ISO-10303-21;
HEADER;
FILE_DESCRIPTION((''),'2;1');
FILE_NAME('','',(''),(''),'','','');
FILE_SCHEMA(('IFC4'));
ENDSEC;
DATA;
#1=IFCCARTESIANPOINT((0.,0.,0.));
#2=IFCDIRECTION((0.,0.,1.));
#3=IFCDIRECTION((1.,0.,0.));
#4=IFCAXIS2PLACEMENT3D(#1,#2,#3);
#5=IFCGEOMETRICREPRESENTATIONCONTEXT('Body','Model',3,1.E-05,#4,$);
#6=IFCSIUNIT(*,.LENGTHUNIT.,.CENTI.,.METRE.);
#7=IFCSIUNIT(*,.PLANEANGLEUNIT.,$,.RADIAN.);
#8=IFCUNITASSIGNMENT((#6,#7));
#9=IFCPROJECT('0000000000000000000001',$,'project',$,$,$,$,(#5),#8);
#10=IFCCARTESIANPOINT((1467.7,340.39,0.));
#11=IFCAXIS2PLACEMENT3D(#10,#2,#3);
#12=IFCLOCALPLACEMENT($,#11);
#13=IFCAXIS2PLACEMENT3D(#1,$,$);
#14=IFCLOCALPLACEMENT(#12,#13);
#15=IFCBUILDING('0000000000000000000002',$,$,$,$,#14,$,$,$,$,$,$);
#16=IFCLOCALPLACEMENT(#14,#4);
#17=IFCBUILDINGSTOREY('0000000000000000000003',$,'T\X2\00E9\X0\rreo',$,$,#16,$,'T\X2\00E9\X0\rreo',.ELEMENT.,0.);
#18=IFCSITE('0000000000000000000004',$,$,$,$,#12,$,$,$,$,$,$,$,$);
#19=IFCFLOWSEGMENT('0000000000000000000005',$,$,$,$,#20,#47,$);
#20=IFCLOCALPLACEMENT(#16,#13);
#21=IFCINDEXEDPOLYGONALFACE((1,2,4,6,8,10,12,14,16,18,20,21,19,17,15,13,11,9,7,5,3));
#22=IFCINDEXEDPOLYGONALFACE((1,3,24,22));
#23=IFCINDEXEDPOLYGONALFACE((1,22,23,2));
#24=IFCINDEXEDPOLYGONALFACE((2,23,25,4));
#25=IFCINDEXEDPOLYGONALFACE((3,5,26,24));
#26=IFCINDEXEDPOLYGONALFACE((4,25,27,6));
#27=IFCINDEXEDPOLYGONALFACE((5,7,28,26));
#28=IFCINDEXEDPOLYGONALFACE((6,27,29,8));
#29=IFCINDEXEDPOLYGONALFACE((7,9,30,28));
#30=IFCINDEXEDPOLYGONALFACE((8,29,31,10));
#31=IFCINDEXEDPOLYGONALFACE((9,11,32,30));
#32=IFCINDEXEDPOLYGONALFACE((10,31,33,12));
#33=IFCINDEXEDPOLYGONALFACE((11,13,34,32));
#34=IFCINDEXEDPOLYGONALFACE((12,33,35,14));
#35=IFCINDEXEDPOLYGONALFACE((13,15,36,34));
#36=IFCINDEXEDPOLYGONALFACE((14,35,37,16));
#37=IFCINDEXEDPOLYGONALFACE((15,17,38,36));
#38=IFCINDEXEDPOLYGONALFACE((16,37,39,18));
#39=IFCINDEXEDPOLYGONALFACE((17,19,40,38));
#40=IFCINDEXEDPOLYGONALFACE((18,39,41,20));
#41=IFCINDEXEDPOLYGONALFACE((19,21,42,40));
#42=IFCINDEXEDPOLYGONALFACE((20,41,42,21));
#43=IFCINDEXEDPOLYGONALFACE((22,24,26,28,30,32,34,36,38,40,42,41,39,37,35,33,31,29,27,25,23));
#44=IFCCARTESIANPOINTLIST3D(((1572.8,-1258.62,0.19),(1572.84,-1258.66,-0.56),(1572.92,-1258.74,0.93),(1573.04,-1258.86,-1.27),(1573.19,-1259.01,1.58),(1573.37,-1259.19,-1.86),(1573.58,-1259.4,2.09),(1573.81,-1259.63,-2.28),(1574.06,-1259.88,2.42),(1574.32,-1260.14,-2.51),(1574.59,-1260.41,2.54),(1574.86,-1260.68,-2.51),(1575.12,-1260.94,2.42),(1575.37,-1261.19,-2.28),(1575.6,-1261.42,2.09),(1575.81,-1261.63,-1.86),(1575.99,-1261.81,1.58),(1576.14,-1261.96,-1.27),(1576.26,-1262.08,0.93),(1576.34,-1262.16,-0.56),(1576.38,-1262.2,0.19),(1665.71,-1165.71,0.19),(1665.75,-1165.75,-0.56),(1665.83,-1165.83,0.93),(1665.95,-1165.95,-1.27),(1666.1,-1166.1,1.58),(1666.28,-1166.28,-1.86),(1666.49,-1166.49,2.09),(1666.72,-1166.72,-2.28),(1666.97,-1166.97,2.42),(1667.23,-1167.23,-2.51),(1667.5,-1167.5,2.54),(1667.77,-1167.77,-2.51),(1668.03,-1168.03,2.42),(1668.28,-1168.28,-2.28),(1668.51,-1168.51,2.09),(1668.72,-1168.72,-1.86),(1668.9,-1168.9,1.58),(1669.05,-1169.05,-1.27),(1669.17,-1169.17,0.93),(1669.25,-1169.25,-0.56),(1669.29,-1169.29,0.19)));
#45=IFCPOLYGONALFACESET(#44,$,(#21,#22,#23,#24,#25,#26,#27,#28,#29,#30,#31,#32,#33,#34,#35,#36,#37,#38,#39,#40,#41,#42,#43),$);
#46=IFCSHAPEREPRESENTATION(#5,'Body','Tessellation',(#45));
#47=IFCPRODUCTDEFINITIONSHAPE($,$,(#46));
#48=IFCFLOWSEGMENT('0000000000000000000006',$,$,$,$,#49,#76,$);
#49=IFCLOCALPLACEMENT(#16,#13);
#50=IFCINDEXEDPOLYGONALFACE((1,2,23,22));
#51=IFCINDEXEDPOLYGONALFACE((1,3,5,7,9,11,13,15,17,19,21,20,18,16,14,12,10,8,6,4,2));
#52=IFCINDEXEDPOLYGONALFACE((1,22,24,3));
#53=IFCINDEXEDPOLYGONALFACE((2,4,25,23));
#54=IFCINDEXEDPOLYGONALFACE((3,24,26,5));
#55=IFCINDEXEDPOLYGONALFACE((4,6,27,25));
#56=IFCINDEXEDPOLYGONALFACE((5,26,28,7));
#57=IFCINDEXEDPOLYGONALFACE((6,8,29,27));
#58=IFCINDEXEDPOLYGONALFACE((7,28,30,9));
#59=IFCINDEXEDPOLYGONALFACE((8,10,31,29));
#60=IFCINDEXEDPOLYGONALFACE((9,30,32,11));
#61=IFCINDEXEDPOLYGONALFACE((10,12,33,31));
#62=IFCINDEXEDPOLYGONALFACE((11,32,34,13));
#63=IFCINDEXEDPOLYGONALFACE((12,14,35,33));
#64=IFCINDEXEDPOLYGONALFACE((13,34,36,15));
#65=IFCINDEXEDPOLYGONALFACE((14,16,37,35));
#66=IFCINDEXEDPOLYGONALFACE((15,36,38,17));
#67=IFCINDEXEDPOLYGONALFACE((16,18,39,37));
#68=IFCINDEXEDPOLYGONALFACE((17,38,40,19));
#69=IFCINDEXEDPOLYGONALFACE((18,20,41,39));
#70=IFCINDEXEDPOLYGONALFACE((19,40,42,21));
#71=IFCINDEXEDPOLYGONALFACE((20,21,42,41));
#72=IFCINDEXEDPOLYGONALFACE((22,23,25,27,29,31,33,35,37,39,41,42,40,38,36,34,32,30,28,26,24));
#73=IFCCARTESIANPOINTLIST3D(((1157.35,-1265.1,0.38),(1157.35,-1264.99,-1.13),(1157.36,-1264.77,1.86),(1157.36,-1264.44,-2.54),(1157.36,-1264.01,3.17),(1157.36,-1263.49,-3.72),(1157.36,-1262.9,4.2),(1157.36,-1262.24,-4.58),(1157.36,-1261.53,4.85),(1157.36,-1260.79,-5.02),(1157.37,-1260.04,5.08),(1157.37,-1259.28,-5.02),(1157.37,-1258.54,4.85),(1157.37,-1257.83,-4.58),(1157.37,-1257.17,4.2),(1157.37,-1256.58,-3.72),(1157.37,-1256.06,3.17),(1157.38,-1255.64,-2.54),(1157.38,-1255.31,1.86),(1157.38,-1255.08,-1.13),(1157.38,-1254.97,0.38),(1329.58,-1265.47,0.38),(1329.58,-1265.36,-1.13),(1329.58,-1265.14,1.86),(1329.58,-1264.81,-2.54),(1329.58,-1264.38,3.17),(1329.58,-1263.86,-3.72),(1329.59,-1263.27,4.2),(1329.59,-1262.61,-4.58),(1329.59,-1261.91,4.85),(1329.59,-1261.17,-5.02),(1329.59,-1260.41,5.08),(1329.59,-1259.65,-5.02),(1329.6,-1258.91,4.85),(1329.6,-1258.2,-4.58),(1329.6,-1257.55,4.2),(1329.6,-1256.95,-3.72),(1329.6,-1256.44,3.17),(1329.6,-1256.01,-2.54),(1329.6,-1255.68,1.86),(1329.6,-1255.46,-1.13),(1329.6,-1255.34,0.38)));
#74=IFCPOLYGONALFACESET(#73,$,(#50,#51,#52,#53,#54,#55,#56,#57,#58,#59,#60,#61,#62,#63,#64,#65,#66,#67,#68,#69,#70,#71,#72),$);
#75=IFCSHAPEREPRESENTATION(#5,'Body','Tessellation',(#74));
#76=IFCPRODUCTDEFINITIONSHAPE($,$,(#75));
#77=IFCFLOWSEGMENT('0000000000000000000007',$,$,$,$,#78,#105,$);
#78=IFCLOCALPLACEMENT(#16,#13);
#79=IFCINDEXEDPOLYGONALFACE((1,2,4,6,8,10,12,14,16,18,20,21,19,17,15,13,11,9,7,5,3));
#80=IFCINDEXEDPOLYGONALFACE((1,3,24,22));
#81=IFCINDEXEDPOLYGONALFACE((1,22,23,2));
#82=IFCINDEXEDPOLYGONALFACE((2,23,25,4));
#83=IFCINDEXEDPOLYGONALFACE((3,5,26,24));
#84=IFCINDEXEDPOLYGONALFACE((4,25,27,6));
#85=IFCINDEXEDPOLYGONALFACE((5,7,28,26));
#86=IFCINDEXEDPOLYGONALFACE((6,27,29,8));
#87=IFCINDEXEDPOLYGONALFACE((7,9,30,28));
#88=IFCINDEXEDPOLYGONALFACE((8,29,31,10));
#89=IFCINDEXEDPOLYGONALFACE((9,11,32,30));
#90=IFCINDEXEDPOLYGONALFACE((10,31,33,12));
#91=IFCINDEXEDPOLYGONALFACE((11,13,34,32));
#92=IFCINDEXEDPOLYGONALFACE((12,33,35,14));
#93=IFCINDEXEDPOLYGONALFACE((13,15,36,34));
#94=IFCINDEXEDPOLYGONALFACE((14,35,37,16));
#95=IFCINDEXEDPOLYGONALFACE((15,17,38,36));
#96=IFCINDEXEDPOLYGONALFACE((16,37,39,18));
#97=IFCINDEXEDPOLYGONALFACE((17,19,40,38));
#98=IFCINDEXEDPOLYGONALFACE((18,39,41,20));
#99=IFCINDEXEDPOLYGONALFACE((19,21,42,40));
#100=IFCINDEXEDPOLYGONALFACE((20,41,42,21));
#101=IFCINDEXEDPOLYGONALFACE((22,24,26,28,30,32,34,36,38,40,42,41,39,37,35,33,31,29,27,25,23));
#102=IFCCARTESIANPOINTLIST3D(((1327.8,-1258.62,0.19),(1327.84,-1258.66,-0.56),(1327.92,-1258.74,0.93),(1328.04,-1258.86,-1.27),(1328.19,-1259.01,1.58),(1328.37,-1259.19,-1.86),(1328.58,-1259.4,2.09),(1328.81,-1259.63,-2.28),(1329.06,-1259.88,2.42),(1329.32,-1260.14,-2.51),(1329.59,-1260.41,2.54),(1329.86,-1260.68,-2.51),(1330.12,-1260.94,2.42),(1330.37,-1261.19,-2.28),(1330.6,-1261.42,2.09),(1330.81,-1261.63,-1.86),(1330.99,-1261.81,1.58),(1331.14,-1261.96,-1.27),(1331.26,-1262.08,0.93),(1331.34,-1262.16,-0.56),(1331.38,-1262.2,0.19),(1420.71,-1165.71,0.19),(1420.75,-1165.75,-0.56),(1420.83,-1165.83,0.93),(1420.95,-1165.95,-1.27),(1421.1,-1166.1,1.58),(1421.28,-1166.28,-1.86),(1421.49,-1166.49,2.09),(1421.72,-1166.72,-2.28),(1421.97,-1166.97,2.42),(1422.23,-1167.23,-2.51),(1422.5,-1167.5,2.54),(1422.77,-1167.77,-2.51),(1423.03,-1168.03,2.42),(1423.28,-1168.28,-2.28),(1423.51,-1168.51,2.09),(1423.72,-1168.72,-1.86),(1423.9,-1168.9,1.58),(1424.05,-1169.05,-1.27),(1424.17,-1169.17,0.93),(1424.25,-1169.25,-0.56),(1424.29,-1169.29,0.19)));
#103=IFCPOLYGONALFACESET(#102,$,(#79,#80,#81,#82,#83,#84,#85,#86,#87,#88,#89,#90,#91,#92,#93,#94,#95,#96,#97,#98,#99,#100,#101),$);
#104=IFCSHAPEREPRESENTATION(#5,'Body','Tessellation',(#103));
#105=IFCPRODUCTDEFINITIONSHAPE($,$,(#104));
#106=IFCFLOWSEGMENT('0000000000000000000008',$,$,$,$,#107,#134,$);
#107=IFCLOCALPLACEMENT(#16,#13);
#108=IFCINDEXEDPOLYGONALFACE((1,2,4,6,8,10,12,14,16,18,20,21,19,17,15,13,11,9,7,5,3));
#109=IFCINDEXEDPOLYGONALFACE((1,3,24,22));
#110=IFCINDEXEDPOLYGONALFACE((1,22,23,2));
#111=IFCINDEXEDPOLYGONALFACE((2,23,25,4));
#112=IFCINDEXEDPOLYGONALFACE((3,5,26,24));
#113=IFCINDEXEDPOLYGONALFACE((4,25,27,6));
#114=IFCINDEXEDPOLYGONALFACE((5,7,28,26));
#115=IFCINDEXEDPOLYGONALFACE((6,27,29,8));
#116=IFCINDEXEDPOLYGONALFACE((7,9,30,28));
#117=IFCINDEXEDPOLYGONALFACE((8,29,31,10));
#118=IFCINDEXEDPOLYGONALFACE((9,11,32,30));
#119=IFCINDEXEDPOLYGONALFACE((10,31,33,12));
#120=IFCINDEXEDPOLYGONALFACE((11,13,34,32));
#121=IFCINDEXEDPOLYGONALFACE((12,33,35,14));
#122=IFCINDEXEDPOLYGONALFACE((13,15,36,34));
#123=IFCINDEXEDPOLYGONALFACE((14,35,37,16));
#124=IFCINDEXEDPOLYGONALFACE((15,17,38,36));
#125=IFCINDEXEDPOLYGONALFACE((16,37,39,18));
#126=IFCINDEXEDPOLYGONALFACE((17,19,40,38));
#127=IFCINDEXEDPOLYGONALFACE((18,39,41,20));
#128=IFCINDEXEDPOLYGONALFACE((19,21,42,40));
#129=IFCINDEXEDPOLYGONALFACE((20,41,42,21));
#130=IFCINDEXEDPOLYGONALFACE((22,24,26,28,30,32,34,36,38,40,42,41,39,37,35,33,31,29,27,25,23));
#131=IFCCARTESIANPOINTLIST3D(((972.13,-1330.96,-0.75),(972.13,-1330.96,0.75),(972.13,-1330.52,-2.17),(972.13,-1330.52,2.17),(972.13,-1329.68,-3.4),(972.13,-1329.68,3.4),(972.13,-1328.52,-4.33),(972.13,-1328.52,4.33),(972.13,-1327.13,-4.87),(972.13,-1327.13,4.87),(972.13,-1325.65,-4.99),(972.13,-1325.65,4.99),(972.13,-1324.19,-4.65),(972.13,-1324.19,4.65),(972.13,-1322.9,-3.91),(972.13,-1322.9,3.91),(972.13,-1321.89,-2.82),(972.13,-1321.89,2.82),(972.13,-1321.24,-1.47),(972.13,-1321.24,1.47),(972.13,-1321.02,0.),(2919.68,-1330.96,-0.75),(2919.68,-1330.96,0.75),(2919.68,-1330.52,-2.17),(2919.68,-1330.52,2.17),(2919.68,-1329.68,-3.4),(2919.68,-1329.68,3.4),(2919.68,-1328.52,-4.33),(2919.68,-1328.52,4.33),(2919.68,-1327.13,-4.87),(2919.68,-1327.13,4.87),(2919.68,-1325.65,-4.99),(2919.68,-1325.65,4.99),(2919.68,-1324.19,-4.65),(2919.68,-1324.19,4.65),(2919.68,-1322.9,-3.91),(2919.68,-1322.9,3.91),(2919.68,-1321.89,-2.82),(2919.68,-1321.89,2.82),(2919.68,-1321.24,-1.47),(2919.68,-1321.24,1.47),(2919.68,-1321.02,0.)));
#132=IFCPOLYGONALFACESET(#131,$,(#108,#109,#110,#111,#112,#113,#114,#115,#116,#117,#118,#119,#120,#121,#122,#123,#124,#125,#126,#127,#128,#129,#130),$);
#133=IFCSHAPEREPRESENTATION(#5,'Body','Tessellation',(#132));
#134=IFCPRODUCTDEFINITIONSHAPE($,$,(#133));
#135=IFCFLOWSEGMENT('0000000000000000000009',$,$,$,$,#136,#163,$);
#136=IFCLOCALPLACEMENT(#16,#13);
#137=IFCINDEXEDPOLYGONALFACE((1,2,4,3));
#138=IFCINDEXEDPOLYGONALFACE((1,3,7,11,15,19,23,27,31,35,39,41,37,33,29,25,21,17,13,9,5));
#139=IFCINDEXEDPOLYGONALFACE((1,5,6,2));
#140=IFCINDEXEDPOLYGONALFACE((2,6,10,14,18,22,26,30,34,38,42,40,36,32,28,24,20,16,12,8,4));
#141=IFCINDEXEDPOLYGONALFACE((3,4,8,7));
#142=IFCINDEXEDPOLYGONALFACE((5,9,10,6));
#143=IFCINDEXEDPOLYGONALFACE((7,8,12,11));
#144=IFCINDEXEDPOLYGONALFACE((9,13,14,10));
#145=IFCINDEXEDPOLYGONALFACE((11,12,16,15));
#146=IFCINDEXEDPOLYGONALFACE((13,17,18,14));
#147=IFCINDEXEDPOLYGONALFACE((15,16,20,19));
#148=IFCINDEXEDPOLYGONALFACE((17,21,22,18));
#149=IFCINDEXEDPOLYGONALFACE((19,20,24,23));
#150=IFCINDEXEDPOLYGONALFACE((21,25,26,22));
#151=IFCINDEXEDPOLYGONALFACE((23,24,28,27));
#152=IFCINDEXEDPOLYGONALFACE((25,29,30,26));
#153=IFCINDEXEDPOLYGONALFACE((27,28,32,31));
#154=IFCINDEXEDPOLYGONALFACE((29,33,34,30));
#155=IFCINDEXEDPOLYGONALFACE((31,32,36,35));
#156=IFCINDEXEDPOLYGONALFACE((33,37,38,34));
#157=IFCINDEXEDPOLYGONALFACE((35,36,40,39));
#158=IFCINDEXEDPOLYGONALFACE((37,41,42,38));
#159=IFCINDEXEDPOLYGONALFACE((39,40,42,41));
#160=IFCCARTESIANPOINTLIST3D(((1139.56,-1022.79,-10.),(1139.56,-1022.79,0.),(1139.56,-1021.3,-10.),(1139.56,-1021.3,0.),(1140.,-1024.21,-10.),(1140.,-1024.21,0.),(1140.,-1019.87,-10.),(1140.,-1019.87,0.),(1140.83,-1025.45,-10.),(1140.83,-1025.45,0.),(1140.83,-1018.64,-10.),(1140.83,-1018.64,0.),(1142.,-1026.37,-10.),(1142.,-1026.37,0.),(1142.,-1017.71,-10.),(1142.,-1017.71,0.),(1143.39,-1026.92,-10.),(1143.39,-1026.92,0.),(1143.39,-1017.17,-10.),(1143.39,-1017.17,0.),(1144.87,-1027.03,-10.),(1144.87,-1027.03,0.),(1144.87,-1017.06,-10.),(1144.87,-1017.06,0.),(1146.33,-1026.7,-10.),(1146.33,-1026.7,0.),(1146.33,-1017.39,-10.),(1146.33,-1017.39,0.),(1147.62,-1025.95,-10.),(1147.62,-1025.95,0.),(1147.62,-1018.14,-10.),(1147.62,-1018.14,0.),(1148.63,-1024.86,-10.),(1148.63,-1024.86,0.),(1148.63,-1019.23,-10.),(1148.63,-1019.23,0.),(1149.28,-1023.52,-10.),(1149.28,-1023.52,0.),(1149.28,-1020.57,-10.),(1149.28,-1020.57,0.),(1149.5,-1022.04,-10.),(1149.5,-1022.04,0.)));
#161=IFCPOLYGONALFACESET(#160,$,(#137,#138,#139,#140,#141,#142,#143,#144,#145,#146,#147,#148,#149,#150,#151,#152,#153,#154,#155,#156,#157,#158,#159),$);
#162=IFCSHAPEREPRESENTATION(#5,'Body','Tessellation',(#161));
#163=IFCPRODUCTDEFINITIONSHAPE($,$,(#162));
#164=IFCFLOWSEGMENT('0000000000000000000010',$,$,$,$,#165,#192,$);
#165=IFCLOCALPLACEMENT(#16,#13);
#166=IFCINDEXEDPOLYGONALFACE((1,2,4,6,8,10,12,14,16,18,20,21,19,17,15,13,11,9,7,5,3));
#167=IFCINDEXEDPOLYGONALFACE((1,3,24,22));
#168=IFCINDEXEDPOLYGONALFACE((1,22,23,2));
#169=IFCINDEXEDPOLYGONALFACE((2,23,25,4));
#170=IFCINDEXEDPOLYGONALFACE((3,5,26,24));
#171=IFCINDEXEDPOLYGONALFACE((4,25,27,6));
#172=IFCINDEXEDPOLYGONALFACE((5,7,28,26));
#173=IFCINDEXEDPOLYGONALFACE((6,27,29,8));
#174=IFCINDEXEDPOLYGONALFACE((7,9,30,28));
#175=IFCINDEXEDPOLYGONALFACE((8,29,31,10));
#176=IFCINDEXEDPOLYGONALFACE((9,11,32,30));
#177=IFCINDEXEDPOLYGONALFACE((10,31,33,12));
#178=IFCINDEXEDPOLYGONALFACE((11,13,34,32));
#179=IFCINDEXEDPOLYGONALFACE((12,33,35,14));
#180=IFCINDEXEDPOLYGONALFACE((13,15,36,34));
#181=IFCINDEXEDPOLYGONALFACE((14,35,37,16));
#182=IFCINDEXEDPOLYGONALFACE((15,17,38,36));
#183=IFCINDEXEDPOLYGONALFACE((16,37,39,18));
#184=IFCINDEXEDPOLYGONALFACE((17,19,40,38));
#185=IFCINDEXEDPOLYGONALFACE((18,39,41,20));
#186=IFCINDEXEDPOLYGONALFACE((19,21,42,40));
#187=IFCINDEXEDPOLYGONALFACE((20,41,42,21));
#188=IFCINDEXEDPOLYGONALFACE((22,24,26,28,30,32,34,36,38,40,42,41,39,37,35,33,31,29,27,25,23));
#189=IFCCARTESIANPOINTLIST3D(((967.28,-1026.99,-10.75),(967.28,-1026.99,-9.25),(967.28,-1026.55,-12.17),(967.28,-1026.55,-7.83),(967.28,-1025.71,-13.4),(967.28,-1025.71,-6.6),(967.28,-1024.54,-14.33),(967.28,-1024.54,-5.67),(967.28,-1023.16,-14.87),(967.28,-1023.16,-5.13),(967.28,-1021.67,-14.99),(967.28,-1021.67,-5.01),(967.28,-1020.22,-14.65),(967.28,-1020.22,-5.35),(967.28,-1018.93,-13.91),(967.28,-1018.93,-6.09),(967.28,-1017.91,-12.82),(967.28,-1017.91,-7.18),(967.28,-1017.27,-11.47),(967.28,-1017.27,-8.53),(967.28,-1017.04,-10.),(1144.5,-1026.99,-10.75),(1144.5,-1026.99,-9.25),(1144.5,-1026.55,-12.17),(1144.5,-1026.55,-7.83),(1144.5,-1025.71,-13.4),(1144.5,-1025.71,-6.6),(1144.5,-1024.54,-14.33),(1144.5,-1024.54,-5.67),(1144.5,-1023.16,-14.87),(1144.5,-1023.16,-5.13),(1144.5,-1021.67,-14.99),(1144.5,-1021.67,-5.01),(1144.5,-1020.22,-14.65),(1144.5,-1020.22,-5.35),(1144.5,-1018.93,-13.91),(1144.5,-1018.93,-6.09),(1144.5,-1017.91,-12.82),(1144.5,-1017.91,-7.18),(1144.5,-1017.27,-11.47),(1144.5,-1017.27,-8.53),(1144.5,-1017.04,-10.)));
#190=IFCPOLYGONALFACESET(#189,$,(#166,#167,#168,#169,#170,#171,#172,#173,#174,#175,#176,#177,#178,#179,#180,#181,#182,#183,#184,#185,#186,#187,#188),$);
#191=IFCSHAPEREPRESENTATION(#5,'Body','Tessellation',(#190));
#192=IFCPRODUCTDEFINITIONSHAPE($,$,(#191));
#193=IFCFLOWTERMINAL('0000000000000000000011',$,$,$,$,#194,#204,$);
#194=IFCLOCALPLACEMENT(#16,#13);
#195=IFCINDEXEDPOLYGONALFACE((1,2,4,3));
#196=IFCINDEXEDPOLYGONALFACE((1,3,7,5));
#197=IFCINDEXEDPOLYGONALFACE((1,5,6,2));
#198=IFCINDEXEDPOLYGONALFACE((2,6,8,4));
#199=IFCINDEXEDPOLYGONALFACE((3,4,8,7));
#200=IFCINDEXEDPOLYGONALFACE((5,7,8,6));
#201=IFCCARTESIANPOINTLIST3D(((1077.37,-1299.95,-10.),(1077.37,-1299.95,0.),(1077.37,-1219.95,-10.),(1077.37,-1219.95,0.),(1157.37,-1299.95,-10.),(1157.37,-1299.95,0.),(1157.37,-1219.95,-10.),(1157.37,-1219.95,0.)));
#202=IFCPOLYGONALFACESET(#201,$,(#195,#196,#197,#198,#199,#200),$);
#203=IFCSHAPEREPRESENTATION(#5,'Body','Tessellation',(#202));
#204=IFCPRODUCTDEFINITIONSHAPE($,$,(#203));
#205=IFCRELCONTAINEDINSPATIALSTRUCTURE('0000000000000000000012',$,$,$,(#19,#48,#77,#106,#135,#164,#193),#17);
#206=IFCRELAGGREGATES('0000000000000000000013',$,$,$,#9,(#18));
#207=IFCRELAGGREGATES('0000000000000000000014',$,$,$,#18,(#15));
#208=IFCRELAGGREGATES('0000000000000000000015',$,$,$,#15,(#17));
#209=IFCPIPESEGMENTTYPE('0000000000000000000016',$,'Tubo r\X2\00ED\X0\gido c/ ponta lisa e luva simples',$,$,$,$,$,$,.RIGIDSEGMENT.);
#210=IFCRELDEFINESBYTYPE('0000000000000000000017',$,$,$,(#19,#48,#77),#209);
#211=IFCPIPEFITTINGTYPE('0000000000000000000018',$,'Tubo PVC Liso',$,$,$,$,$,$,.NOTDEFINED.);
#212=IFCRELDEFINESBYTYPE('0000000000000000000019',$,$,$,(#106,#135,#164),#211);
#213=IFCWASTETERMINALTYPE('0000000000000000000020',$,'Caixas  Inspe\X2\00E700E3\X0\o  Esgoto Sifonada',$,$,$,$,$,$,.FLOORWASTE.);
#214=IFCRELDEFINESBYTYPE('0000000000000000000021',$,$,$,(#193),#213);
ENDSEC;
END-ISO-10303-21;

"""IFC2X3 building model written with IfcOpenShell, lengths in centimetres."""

from ifc_helpers import new_model, si_unit, frame, origin, origin_with_axes, origin_2d_with_axis, place, context, project, spatial, rectangle, circle, extrude, type_object, element, save


model = new_model("IFC2X3")

# Units and contexts
model_context = context("Model", 3, precision=1e-05, world=origin_with_axes(), identifier="Body")
ifc_project = project(units=[si_unit("LENGTHUNIT", "METRE", prefix="CENTI"), si_unit("PLANEANGLEUNIT", "RADIAN")], contexts=[model_context])

# Site, building, storey
site_placement = place(None, frame((1467.7, 340.39, 0.0), z_axis=(0.0, 0.0, 1.0), x_axis=(1.0, 0.0, 0.0)))
site = spatial("IfcSite", under=ifc_project, at=site_placement)
building_placement = place(site_placement, origin())
building = spatial("IfcBuilding", under=site, at=building_placement)
storey_placement = place(building_placement, origin_with_axes())
storey = spatial("IfcBuildingStorey", under=building, at=storey_placement, Name="Térreo", LongName="Térreo", CompositionType="ELEMENT", Elevation=0.0)

# Flow segments
pipe_segment_type_1 = type_object("IfcPipeSegmentType", Name="Tubo rígido c/ ponta lisa e luva simples", PredefinedType="RIGIDSEGMENT")
flow_segment_1_placement = place(storey_placement, frame((1621.05, -1213.95, 2.54), z_axis=(0.0, 0.0, 1.0), x_axis=(1.0, 0.0, 0.0)))
element("IfcFlowSegment", 1, at=flow_segment_1_placement, inside=storey, type_object=pipe_segment_type_1, context=model_context, shape_type="SolidModel", body=[
    extrude(circle(Radius=2.54, at=origin_2d_with_axis()), frame((46.45, 46.45, -2.54), z_axis=(-0.707107, -0.707107, 0.0), x_axis=(0.0, 0.0, 1.0)), (0.0, 0.0, 1.0), 131.39),
])
flow_segment_2_placement = place(storey_placement, frame((1243.48, -1260.22, 5.08), z_axis=(0.0, 0.0, 1.0), x_axis=(1.0, 0.0, 0.0)))
element("IfcFlowSegment", 2, at=flow_segment_2_placement, inside=storey, type_object=pipe_segment_type_1, context=model_context, shape_type="SolidModel", body=[
    extrude(circle(Radius=5.08, at=origin_2d_with_axis()), frame((86.11, -0.19, -5.08), z_axis=(-1.0, 0.002157, 0.0), x_axis=(0.0, 0.0, 1.0)), (0.0, 0.0, 1.0), 172.23),
])
flow_segment_3_placement = place(storey_placement, frame((1376.05, -1213.95, 2.54), z_axis=(0.0, 0.0, 1.0), x_axis=(1.0, 0.0, 0.0)))
element("IfcFlowSegment", 3, at=flow_segment_3_placement, inside=storey, type_object=pipe_segment_type_1, context=model_context, shape_type="SolidModel", body=[
    extrude(circle(Radius=2.54, at=origin_2d_with_axis()), frame((46.45, 46.45, -2.54), z_axis=(-0.707107, -0.707107, 0.0), x_axis=(0.0, 0.0, 1.0)), (0.0, 0.0, 1.0), 131.39),
])
pipe_fitting_type_1 = type_object("IfcPipeFittingType", Name="Tubo PVC Liso", PredefinedType="NOTDEFINED")
flow_segment_4_placement = place(storey_placement, frame((1945.9, -1326.02, 5.0), z_axis=(0.0, 0.0, 1.0), x_axis=(1.0, 0.0, 0.0)))
element("IfcFlowSegment", 4, at=flow_segment_4_placement, inside=storey, type_object=pipe_fitting_type_1, context=model_context, shape_type="SolidModel", body=[
    extrude(circle(Radius=5.0, at=origin_2d_with_axis()), frame((973.78, 0.0, -5.0), z_axis=(-1.0, 0.0, 0.0), x_axis=(0.0, 1.0, 0.0)), (0.0, 0.0, 1.0), 1947.55),
])
flow_segment_5_placement = place(storey_placement, frame((1144.5, -1022.04, 0.0), z_axis=(0.0, 0.0, 1.0), x_axis=(1.0, 0.0, 0.0)))
element("IfcFlowSegment", 5, at=flow_segment_5_placement, inside=storey, type_object=pipe_fitting_type_1, context=model_context, shape_type="SolidModel", body=[
    extrude(circle(Radius=5.0, at=origin_2d_with_axis()), frame((0.0, 0.0, 0.0), z_axis=(0.0, 0.0, -1.0), x_axis=(1.0, 0.0, 0.0)), (0.0, 0.0, 1.0), 10.0),
])
flow_segment_6_placement = place(storey_placement, frame((1055.89, -1022.04, -5.0), z_axis=(0.0, 0.0, 1.0), x_axis=(1.0, 0.0, 0.0)))
element("IfcFlowSegment", 6, at=flow_segment_6_placement, inside=storey, type_object=pipe_fitting_type_1, context=model_context, shape_type="SolidModel", body=[
    extrude(circle(Radius=5.0, at=origin_2d_with_axis()), frame((88.61, 0.0, -5.0), z_axis=(-1.0, 0.0, 0.0), x_axis=(0.0, 1.0, 0.0)), (0.0, 0.0, 1.0), 177.22),
])

# Flow terminal
waste_terminal_type_1 = type_object("IfcWasteTerminalType", Name="Caixas  Inspeção  Esgoto Sifonada", PredefinedType="FLOORWASTE")
flow_terminal_1_placement = place(storey_placement, frame((1117.37, -1259.95, 0.0), z_axis=(0.0, 0.0, 1.0), x_axis=(1.0, 0.0, 0.0)))
element("IfcFlowTerminal", 7, at=flow_terminal_1_placement, inside=storey, type_object=waste_terminal_type_1, context=model_context, shape_type="SolidModel", body=[
    extrude(rectangle(XDim=80.0, YDim=80.0, at=origin_2d_with_axis()), frame((0.0, 0.0, -10.0), z_axis=(0.0, 0.0, 1.0), x_axis=(0.0, -1.0, 0.0)), (0.0, 0.0, 1.0), 10.0),
])

save(model, "model.ifc")
